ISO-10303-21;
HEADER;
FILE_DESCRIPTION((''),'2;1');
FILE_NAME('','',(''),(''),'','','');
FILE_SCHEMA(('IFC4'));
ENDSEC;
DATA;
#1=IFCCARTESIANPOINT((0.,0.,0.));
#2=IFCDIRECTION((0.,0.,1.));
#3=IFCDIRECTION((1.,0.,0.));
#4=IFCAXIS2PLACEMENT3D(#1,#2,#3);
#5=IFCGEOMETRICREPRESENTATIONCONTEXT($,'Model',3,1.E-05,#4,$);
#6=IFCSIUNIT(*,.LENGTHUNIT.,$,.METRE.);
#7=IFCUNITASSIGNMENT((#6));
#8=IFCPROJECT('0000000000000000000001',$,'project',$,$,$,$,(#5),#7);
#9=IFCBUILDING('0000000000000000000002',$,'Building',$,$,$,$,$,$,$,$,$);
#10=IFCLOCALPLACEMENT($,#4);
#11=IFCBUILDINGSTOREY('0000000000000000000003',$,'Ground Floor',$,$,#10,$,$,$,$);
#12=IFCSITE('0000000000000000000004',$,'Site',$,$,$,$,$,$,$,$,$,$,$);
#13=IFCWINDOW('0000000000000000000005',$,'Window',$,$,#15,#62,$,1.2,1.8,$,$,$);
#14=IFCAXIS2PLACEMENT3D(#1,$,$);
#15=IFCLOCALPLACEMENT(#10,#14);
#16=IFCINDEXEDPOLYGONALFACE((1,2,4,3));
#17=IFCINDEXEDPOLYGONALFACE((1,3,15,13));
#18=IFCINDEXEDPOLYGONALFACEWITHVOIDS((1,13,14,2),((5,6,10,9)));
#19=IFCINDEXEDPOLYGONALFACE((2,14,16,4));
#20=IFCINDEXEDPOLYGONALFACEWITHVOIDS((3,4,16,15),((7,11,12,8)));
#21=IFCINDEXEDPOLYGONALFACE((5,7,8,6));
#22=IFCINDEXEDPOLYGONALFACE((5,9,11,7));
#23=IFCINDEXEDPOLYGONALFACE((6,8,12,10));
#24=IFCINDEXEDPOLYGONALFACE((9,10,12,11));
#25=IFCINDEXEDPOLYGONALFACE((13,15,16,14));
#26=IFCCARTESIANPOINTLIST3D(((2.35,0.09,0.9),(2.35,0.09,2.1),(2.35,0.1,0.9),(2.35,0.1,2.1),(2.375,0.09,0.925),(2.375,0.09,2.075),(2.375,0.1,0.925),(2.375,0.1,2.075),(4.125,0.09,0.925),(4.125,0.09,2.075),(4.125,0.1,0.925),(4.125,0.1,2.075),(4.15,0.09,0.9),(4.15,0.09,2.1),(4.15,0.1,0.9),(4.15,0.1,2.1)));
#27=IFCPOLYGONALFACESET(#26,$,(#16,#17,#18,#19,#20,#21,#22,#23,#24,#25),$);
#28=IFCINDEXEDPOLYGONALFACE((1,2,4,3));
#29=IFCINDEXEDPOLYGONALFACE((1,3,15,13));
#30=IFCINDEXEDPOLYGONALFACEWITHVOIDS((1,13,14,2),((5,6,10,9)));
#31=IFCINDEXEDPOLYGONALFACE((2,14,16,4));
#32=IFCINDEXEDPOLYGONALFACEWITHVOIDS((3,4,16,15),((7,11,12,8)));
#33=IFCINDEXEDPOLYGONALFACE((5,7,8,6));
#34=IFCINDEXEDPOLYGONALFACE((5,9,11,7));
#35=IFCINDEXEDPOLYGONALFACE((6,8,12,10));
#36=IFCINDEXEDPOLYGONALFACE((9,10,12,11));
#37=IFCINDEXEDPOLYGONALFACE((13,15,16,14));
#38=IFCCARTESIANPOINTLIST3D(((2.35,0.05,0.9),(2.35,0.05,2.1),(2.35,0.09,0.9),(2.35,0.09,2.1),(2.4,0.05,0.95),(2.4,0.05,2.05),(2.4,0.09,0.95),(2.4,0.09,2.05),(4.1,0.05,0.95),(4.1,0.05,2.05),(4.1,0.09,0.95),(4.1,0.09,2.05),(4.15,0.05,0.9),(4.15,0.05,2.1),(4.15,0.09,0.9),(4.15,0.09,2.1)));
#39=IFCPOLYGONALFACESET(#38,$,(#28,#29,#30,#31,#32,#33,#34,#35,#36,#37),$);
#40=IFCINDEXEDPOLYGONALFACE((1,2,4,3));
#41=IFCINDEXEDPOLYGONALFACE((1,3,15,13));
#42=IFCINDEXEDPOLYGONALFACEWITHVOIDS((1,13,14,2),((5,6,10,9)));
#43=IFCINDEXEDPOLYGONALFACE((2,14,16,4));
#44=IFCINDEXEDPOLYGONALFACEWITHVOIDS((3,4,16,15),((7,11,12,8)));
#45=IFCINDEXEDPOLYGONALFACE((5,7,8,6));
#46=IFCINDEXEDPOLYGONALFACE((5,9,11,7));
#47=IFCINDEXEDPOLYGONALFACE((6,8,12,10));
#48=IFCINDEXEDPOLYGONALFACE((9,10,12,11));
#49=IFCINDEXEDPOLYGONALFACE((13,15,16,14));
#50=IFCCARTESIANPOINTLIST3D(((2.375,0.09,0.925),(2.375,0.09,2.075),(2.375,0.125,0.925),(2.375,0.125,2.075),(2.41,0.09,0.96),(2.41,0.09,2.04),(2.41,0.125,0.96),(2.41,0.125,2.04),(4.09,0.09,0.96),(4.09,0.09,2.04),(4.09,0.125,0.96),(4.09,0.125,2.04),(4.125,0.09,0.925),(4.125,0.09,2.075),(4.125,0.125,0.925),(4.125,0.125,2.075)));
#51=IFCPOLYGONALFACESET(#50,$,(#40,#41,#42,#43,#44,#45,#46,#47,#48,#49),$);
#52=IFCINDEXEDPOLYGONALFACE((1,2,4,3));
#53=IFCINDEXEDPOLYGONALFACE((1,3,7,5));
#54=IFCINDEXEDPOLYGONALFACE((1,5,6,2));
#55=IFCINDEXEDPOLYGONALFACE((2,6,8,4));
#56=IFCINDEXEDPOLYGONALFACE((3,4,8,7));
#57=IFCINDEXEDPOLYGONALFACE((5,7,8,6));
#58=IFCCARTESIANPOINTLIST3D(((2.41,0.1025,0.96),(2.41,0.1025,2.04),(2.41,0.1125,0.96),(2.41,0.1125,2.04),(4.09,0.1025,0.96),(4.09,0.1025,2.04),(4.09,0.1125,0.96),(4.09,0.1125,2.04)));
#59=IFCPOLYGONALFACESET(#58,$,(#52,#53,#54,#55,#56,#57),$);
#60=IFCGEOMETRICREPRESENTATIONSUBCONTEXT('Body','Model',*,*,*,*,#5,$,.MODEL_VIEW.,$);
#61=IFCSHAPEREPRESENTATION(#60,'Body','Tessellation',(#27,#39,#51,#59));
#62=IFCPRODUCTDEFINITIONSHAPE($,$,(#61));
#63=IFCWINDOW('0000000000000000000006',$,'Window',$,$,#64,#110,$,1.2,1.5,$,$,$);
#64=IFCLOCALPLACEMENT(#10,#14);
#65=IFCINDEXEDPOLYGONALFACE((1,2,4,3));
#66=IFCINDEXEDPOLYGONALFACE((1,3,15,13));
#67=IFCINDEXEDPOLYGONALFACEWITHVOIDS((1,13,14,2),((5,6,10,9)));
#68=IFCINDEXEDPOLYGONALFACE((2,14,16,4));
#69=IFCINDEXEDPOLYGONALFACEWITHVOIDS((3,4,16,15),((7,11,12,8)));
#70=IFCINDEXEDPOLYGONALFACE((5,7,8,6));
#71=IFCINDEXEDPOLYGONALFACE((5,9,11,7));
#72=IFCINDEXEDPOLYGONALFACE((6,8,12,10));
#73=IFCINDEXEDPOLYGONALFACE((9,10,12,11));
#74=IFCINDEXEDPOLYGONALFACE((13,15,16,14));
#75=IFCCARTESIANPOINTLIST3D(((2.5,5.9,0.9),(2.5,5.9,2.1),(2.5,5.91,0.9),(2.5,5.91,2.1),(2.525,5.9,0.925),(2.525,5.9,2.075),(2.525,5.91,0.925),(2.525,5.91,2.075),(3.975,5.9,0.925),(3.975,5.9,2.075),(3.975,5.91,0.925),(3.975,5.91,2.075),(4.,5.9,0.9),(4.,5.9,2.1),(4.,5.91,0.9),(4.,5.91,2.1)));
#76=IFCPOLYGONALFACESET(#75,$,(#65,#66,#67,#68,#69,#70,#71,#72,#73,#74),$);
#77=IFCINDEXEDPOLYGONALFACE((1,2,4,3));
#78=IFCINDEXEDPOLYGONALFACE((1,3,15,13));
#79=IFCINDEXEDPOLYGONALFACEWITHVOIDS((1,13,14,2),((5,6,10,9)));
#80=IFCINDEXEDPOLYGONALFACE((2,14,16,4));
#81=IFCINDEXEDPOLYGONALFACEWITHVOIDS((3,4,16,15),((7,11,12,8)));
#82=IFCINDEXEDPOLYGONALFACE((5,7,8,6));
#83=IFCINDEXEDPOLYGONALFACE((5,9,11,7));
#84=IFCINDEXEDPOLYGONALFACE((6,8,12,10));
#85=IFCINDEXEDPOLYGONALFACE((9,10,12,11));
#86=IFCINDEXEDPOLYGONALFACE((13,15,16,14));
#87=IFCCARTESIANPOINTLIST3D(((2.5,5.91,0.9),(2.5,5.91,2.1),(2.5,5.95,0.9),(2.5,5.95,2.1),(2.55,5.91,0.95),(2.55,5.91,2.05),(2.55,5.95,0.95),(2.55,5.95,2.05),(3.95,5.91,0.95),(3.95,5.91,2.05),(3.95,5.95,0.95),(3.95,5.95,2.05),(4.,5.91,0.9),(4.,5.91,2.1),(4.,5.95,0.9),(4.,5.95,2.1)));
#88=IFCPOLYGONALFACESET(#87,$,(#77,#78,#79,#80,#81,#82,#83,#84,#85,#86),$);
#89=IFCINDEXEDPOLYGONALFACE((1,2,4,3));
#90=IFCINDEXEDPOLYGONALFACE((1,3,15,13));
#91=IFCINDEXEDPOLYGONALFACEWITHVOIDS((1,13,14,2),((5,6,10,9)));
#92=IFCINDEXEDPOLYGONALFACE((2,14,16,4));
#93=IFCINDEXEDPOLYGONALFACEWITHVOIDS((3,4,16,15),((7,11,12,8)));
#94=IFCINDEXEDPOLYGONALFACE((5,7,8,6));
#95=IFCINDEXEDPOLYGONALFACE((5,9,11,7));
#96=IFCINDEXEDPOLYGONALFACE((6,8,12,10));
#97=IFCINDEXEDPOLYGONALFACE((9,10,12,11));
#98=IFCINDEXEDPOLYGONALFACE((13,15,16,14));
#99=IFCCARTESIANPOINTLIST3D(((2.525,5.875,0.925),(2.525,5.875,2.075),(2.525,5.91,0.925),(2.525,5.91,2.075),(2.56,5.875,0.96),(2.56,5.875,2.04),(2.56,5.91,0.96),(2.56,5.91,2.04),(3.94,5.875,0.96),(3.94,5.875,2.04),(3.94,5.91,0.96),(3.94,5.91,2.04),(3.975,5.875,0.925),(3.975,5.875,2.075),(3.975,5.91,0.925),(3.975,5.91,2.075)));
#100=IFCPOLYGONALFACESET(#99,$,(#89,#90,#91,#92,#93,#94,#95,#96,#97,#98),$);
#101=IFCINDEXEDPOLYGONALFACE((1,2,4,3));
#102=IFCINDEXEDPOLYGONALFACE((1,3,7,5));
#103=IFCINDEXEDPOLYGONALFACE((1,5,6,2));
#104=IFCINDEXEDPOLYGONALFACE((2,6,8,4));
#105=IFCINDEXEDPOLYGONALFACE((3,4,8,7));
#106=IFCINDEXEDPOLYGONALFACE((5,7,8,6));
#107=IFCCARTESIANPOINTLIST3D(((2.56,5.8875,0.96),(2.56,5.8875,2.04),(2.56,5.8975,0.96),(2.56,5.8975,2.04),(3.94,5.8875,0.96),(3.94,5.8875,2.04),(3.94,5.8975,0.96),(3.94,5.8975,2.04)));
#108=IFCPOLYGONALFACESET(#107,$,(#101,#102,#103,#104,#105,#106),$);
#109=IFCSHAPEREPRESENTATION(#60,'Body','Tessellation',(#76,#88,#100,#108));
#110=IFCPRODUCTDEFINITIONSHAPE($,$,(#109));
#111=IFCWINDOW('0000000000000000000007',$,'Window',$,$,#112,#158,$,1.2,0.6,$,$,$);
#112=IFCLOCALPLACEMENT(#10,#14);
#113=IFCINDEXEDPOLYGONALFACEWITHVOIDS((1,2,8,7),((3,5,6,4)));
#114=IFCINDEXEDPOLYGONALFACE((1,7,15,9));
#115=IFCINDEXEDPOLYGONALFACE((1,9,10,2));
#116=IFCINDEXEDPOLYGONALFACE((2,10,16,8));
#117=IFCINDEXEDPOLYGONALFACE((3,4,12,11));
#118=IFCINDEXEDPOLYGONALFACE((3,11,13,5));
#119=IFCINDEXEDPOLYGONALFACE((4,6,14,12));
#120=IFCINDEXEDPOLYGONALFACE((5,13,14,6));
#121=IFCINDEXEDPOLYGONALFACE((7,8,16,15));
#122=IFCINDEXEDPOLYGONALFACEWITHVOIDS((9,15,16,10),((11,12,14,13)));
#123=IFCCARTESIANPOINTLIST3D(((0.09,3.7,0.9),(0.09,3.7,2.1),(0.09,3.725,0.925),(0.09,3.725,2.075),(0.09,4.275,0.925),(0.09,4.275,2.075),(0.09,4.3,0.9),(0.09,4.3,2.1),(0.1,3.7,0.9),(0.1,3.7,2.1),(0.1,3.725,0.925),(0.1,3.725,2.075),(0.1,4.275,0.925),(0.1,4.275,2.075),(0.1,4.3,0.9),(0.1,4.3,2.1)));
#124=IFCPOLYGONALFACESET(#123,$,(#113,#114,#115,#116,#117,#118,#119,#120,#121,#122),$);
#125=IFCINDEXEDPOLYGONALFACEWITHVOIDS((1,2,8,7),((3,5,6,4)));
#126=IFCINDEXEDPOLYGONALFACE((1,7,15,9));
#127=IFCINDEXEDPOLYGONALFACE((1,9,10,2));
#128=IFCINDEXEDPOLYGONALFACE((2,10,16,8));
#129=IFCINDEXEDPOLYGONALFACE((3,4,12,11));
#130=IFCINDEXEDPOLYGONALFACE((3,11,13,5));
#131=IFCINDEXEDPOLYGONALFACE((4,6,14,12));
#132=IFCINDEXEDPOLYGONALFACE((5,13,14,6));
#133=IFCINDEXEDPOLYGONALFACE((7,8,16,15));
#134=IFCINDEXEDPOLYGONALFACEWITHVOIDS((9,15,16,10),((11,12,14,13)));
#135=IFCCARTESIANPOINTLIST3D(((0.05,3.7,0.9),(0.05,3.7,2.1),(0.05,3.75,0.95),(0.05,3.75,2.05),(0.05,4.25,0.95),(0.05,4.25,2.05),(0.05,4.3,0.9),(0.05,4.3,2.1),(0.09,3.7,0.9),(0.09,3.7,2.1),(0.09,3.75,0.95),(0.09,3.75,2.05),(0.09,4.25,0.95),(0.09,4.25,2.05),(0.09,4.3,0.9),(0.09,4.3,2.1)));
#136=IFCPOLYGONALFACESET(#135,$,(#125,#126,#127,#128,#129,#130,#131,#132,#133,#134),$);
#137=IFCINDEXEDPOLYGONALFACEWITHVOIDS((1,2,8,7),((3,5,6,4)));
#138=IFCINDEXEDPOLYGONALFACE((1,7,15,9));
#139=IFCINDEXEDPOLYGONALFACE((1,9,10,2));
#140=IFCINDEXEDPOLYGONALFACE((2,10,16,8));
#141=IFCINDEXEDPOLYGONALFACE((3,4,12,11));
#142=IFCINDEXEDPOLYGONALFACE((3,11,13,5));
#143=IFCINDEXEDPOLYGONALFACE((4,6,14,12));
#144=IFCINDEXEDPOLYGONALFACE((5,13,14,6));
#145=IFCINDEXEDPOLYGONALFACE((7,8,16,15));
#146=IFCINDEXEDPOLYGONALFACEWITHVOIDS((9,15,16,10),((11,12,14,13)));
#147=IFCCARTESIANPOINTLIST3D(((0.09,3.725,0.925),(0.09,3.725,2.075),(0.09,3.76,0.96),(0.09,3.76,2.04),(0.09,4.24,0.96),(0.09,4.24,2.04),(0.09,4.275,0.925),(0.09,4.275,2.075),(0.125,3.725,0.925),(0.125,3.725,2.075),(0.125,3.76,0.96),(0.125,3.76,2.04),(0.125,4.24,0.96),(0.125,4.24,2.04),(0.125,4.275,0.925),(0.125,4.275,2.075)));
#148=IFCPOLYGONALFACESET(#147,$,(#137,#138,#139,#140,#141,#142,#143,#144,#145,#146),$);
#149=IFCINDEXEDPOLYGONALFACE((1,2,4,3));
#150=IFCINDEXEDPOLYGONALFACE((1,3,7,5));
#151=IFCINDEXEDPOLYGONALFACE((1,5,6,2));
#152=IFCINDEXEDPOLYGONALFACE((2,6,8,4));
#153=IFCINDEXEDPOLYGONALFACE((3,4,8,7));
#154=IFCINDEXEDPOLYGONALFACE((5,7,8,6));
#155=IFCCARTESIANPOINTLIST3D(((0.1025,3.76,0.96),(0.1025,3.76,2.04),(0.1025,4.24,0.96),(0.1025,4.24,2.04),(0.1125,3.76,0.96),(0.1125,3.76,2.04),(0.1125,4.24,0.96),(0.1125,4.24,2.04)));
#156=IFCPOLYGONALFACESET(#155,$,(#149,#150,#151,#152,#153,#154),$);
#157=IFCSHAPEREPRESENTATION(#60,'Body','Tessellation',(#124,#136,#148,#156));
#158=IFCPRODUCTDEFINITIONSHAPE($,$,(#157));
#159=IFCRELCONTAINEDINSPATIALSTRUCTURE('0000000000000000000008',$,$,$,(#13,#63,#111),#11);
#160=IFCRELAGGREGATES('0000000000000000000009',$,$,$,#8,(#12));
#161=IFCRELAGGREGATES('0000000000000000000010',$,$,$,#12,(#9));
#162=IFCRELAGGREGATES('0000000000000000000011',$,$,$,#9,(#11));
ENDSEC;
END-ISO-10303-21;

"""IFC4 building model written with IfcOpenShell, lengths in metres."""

from ifc_helpers import new_model, si_unit, frame, origin_with_axes, place, context, subcontext, project, spatial, line, indexed_curve, outline, extrude, element, save


model = new_model("IFC4")

# Units and contexts
model_context = context("Model", 3, precision=1e-05, world=origin_with_axes())
body_context = subcontext(model_context, "Body", "Model", "MODEL_VIEW")
ifc_project = project(units=[si_unit("LENGTHUNIT", "METRE")], contexts=[model_context])

# Site, building, storey
site = spatial("IfcSite", under=ifc_project, Name="Site")
building = spatial("IfcBuilding", under=site, Name="Building")
storey_placement = place(None, origin_with_axes())
storey = spatial("IfcBuildingStorey", under=building, at=storey_placement, Name="Ground Floor")

# Windows
window_1_placement = place(storey_placement, frame((2.35, 0.0, 0.9), z_axis=(0.0, 0.0, 1.0), x_axis=(1.0, 0.0, 0.0)))
element("IfcWindow", 1, at=window_1_placement, inside=storey, Name="Window", OverallHeight=1.2, OverallWidth=1.8, context=body_context, shape_type="SweptSolid", body=[
    extrude(outline(indexed_curve([(0.0, 0.0), (1.8, 0.0), (1.8, 1.2), (0.0, 1.2)], segments=[line(1, 2, 3, 4, 1)]), holes=[indexed_curve([(0.025, 0.025), (1.775, 0.025), (1.775, 1.175), (0.025, 1.175)], segments=[line(1, 2, 3, 4, 1)])]), frame((0.0, 0.09, 0.0), z_axis=(0.0, -1.0, 0.0), x_axis=(1.0, 0.0, 0.0)), (0.0, 0.0, -1.0), 0.01),
    extrude(outline(indexed_curve([(0.0, 0.0), (1.8, 0.0), (1.8, 1.2), (0.0, 1.2)], segments=[line(1, 2, 3, 4, 1)]), holes=[indexed_curve([(0.05, 0.05), (1.75, 0.05), (1.75, 1.15), (0.05, 1.15)], segments=[line(1, 2, 3, 4, 1)])]), frame((0.0, 0.05, 0.0), z_axis=(0.0, -1.0, 0.0), x_axis=(1.0, 0.0, 0.0)), (0.0, 0.0, -1.0), 0.04),
    extrude(outline(indexed_curve([(0.0, 0.0), (1.75, 0.0), (1.75, 1.15), (0.0, 1.15)], segments=[line(1, 2, 3, 4, 1)]), holes=[indexed_curve([(0.035, 0.035), (1.715, 0.035), (1.715, 1.115), (0.035, 1.115)], segments=[line(1, 2, 3, 4, 1)])]), frame((0.025, 0.09, 0.025), z_axis=(0.0, -1.0, 0.0), x_axis=(1.0, 0.0, 0.0)), (0.0, 0.0, -1.0), 0.035),
    extrude(outline(indexed_curve([(0.035, 0.035), (1.715, 0.035), (1.715, 1.115), (0.035, 1.115)], segments=[line(1, 2, 3, 4, 1)])), frame((0.025, 0.1025, 0.025), z_axis=(0.0, -1.0, 0.0), x_axis=(1.0, 0.0, 0.0)), (0.0, 0.0, -1.0), 0.01),
])
window_2_placement = place(storey_placement, frame((4.0, 6.0, 0.9), z_axis=(0.0, 0.0, 1.0), x_axis=(-1.0, 0.0, 0.0)))
element("IfcWindow", 2, at=window_2_placement, inside=storey, Name="Window", OverallHeight=1.2, OverallWidth=1.5, context=body_context, shape_type="SweptSolid", body=[
    extrude(outline(indexed_curve([(0.0, 0.0), (1.5, 0.0), (1.5, 1.2), (0.0, 1.2)], segments=[line(1, 2, 3, 4, 1)]), holes=[indexed_curve([(0.025, 0.025), (1.475, 0.025), (1.475, 1.175), (0.025, 1.175)], segments=[line(1, 2, 3, 4, 1)])]), frame((0.0, 0.09, 0.0), z_axis=(0.0, -1.0, 0.0), x_axis=(1.0, 0.0, 0.0)), (0.0, 0.0, -1.0), 0.01),
    extrude(outline(indexed_curve([(0.0, 0.0), (1.5, 0.0), (1.5, 1.2), (0.0, 1.2)], segments=[line(1, 2, 3, 4, 1)]), holes=[indexed_curve([(0.05, 0.05), (1.45, 0.05), (1.45, 1.15), (0.05, 1.15)], segments=[line(1, 2, 3, 4, 1)])]), frame((0.0, 0.05, 0.0), z_axis=(0.0, -1.0, 0.0), x_axis=(1.0, 0.0, 0.0)), (0.0, 0.0, -1.0), 0.04),
    extrude(outline(indexed_curve([(0.0, 0.0), (1.45, 0.0), (1.45, 1.15), (0.0, 1.15)], segments=[line(1, 2, 3, 4, 1)]), holes=[indexed_curve([(0.035, 0.035), (1.415, 0.035), (1.415, 1.115), (0.035, 1.115)], segments=[line(1, 2, 3, 4, 1)])]), frame((0.025, 0.09, 0.025), z_axis=(0.0, -1.0, 0.0), x_axis=(1.0, 0.0, 0.0)), (0.0, 0.0, -1.0), 0.035),
    extrude(outline(indexed_curve([(0.035, 0.035), (1.415, 0.035), (1.415, 1.115), (0.035, 1.115)], segments=[line(1, 2, 3, 4, 1)])), frame((0.025, 0.1025, 0.025), z_axis=(0.0, -1.0, 0.0), x_axis=(1.0, 0.0, 0.0)), (0.0, 0.0, -1.0), 0.01),
])
window_3_placement = place(storey_placement, frame((0.0, 4.3, 0.9), z_axis=(0.0, 0.0, 1.0), x_axis=(0.0, -1.0, 0.0)))
element("IfcWindow", 3, at=window_3_placement, inside=storey, Name="Window", OverallHeight=1.2, OverallWidth=0.6, context=body_context, shape_type="SweptSolid", body=[
    extrude(outline(indexed_curve([(0.0, 0.0), (0.6, 0.0), (0.6, 1.2), (0.0, 1.2)], segments=[line(1, 2, 3, 4, 1)]), holes=[indexed_curve([(0.025, 0.025), (0.575, 0.025), (0.575, 1.175), (0.025, 1.175)], segments=[line(1, 2, 3, 4, 1)])]), frame((0.0, 0.09, 0.0), z_axis=(0.0, -1.0, 0.0), x_axis=(1.0, 0.0, 0.0)), (0.0, 0.0, -1.0), 0.01),
    extrude(outline(indexed_curve([(0.0, 0.0), (0.6, 0.0), (0.6, 1.2), (0.0, 1.2)], segments=[line(1, 2, 3, 4, 1)]), holes=[indexed_curve([(0.05, 0.05), (0.55, 0.05), (0.55, 1.15), (0.05, 1.15)], segments=[line(1, 2, 3, 4, 1)])]), frame((0.0, 0.05, 0.0), z_axis=(0.0, -1.0, 0.0), x_axis=(1.0, 0.0, 0.0)), (0.0, 0.0, -1.0), 0.04),
    extrude(outline(indexed_curve([(0.0, 0.0), (0.55, 0.0), (0.55, 1.15), (0.0, 1.15)], segments=[line(1, 2, 3, 4, 1)]), holes=[indexed_curve([(0.035, 0.035), (0.515, 0.035), (0.515, 1.115), (0.035, 1.115)], segments=[line(1, 2, 3, 4, 1)])]), frame((0.025, 0.09, 0.025), z_axis=(0.0, -1.0, 0.0), x_axis=(1.0, 0.0, 0.0)), (0.0, 0.0, -1.0), 0.035),
    extrude(outline(indexed_curve([(0.035, 0.035), (0.515, 0.035), (0.515, 1.115), (0.035, 1.115)], segments=[line(1, 2, 3, 4, 1)])), frame((0.025, 0.1025, 0.025), z_axis=(0.0, -1.0, 0.0), x_axis=(1.0, 0.0, 0.0)), (0.0, 0.0, -1.0), 0.01),
])

save(model, "model.ifc")
